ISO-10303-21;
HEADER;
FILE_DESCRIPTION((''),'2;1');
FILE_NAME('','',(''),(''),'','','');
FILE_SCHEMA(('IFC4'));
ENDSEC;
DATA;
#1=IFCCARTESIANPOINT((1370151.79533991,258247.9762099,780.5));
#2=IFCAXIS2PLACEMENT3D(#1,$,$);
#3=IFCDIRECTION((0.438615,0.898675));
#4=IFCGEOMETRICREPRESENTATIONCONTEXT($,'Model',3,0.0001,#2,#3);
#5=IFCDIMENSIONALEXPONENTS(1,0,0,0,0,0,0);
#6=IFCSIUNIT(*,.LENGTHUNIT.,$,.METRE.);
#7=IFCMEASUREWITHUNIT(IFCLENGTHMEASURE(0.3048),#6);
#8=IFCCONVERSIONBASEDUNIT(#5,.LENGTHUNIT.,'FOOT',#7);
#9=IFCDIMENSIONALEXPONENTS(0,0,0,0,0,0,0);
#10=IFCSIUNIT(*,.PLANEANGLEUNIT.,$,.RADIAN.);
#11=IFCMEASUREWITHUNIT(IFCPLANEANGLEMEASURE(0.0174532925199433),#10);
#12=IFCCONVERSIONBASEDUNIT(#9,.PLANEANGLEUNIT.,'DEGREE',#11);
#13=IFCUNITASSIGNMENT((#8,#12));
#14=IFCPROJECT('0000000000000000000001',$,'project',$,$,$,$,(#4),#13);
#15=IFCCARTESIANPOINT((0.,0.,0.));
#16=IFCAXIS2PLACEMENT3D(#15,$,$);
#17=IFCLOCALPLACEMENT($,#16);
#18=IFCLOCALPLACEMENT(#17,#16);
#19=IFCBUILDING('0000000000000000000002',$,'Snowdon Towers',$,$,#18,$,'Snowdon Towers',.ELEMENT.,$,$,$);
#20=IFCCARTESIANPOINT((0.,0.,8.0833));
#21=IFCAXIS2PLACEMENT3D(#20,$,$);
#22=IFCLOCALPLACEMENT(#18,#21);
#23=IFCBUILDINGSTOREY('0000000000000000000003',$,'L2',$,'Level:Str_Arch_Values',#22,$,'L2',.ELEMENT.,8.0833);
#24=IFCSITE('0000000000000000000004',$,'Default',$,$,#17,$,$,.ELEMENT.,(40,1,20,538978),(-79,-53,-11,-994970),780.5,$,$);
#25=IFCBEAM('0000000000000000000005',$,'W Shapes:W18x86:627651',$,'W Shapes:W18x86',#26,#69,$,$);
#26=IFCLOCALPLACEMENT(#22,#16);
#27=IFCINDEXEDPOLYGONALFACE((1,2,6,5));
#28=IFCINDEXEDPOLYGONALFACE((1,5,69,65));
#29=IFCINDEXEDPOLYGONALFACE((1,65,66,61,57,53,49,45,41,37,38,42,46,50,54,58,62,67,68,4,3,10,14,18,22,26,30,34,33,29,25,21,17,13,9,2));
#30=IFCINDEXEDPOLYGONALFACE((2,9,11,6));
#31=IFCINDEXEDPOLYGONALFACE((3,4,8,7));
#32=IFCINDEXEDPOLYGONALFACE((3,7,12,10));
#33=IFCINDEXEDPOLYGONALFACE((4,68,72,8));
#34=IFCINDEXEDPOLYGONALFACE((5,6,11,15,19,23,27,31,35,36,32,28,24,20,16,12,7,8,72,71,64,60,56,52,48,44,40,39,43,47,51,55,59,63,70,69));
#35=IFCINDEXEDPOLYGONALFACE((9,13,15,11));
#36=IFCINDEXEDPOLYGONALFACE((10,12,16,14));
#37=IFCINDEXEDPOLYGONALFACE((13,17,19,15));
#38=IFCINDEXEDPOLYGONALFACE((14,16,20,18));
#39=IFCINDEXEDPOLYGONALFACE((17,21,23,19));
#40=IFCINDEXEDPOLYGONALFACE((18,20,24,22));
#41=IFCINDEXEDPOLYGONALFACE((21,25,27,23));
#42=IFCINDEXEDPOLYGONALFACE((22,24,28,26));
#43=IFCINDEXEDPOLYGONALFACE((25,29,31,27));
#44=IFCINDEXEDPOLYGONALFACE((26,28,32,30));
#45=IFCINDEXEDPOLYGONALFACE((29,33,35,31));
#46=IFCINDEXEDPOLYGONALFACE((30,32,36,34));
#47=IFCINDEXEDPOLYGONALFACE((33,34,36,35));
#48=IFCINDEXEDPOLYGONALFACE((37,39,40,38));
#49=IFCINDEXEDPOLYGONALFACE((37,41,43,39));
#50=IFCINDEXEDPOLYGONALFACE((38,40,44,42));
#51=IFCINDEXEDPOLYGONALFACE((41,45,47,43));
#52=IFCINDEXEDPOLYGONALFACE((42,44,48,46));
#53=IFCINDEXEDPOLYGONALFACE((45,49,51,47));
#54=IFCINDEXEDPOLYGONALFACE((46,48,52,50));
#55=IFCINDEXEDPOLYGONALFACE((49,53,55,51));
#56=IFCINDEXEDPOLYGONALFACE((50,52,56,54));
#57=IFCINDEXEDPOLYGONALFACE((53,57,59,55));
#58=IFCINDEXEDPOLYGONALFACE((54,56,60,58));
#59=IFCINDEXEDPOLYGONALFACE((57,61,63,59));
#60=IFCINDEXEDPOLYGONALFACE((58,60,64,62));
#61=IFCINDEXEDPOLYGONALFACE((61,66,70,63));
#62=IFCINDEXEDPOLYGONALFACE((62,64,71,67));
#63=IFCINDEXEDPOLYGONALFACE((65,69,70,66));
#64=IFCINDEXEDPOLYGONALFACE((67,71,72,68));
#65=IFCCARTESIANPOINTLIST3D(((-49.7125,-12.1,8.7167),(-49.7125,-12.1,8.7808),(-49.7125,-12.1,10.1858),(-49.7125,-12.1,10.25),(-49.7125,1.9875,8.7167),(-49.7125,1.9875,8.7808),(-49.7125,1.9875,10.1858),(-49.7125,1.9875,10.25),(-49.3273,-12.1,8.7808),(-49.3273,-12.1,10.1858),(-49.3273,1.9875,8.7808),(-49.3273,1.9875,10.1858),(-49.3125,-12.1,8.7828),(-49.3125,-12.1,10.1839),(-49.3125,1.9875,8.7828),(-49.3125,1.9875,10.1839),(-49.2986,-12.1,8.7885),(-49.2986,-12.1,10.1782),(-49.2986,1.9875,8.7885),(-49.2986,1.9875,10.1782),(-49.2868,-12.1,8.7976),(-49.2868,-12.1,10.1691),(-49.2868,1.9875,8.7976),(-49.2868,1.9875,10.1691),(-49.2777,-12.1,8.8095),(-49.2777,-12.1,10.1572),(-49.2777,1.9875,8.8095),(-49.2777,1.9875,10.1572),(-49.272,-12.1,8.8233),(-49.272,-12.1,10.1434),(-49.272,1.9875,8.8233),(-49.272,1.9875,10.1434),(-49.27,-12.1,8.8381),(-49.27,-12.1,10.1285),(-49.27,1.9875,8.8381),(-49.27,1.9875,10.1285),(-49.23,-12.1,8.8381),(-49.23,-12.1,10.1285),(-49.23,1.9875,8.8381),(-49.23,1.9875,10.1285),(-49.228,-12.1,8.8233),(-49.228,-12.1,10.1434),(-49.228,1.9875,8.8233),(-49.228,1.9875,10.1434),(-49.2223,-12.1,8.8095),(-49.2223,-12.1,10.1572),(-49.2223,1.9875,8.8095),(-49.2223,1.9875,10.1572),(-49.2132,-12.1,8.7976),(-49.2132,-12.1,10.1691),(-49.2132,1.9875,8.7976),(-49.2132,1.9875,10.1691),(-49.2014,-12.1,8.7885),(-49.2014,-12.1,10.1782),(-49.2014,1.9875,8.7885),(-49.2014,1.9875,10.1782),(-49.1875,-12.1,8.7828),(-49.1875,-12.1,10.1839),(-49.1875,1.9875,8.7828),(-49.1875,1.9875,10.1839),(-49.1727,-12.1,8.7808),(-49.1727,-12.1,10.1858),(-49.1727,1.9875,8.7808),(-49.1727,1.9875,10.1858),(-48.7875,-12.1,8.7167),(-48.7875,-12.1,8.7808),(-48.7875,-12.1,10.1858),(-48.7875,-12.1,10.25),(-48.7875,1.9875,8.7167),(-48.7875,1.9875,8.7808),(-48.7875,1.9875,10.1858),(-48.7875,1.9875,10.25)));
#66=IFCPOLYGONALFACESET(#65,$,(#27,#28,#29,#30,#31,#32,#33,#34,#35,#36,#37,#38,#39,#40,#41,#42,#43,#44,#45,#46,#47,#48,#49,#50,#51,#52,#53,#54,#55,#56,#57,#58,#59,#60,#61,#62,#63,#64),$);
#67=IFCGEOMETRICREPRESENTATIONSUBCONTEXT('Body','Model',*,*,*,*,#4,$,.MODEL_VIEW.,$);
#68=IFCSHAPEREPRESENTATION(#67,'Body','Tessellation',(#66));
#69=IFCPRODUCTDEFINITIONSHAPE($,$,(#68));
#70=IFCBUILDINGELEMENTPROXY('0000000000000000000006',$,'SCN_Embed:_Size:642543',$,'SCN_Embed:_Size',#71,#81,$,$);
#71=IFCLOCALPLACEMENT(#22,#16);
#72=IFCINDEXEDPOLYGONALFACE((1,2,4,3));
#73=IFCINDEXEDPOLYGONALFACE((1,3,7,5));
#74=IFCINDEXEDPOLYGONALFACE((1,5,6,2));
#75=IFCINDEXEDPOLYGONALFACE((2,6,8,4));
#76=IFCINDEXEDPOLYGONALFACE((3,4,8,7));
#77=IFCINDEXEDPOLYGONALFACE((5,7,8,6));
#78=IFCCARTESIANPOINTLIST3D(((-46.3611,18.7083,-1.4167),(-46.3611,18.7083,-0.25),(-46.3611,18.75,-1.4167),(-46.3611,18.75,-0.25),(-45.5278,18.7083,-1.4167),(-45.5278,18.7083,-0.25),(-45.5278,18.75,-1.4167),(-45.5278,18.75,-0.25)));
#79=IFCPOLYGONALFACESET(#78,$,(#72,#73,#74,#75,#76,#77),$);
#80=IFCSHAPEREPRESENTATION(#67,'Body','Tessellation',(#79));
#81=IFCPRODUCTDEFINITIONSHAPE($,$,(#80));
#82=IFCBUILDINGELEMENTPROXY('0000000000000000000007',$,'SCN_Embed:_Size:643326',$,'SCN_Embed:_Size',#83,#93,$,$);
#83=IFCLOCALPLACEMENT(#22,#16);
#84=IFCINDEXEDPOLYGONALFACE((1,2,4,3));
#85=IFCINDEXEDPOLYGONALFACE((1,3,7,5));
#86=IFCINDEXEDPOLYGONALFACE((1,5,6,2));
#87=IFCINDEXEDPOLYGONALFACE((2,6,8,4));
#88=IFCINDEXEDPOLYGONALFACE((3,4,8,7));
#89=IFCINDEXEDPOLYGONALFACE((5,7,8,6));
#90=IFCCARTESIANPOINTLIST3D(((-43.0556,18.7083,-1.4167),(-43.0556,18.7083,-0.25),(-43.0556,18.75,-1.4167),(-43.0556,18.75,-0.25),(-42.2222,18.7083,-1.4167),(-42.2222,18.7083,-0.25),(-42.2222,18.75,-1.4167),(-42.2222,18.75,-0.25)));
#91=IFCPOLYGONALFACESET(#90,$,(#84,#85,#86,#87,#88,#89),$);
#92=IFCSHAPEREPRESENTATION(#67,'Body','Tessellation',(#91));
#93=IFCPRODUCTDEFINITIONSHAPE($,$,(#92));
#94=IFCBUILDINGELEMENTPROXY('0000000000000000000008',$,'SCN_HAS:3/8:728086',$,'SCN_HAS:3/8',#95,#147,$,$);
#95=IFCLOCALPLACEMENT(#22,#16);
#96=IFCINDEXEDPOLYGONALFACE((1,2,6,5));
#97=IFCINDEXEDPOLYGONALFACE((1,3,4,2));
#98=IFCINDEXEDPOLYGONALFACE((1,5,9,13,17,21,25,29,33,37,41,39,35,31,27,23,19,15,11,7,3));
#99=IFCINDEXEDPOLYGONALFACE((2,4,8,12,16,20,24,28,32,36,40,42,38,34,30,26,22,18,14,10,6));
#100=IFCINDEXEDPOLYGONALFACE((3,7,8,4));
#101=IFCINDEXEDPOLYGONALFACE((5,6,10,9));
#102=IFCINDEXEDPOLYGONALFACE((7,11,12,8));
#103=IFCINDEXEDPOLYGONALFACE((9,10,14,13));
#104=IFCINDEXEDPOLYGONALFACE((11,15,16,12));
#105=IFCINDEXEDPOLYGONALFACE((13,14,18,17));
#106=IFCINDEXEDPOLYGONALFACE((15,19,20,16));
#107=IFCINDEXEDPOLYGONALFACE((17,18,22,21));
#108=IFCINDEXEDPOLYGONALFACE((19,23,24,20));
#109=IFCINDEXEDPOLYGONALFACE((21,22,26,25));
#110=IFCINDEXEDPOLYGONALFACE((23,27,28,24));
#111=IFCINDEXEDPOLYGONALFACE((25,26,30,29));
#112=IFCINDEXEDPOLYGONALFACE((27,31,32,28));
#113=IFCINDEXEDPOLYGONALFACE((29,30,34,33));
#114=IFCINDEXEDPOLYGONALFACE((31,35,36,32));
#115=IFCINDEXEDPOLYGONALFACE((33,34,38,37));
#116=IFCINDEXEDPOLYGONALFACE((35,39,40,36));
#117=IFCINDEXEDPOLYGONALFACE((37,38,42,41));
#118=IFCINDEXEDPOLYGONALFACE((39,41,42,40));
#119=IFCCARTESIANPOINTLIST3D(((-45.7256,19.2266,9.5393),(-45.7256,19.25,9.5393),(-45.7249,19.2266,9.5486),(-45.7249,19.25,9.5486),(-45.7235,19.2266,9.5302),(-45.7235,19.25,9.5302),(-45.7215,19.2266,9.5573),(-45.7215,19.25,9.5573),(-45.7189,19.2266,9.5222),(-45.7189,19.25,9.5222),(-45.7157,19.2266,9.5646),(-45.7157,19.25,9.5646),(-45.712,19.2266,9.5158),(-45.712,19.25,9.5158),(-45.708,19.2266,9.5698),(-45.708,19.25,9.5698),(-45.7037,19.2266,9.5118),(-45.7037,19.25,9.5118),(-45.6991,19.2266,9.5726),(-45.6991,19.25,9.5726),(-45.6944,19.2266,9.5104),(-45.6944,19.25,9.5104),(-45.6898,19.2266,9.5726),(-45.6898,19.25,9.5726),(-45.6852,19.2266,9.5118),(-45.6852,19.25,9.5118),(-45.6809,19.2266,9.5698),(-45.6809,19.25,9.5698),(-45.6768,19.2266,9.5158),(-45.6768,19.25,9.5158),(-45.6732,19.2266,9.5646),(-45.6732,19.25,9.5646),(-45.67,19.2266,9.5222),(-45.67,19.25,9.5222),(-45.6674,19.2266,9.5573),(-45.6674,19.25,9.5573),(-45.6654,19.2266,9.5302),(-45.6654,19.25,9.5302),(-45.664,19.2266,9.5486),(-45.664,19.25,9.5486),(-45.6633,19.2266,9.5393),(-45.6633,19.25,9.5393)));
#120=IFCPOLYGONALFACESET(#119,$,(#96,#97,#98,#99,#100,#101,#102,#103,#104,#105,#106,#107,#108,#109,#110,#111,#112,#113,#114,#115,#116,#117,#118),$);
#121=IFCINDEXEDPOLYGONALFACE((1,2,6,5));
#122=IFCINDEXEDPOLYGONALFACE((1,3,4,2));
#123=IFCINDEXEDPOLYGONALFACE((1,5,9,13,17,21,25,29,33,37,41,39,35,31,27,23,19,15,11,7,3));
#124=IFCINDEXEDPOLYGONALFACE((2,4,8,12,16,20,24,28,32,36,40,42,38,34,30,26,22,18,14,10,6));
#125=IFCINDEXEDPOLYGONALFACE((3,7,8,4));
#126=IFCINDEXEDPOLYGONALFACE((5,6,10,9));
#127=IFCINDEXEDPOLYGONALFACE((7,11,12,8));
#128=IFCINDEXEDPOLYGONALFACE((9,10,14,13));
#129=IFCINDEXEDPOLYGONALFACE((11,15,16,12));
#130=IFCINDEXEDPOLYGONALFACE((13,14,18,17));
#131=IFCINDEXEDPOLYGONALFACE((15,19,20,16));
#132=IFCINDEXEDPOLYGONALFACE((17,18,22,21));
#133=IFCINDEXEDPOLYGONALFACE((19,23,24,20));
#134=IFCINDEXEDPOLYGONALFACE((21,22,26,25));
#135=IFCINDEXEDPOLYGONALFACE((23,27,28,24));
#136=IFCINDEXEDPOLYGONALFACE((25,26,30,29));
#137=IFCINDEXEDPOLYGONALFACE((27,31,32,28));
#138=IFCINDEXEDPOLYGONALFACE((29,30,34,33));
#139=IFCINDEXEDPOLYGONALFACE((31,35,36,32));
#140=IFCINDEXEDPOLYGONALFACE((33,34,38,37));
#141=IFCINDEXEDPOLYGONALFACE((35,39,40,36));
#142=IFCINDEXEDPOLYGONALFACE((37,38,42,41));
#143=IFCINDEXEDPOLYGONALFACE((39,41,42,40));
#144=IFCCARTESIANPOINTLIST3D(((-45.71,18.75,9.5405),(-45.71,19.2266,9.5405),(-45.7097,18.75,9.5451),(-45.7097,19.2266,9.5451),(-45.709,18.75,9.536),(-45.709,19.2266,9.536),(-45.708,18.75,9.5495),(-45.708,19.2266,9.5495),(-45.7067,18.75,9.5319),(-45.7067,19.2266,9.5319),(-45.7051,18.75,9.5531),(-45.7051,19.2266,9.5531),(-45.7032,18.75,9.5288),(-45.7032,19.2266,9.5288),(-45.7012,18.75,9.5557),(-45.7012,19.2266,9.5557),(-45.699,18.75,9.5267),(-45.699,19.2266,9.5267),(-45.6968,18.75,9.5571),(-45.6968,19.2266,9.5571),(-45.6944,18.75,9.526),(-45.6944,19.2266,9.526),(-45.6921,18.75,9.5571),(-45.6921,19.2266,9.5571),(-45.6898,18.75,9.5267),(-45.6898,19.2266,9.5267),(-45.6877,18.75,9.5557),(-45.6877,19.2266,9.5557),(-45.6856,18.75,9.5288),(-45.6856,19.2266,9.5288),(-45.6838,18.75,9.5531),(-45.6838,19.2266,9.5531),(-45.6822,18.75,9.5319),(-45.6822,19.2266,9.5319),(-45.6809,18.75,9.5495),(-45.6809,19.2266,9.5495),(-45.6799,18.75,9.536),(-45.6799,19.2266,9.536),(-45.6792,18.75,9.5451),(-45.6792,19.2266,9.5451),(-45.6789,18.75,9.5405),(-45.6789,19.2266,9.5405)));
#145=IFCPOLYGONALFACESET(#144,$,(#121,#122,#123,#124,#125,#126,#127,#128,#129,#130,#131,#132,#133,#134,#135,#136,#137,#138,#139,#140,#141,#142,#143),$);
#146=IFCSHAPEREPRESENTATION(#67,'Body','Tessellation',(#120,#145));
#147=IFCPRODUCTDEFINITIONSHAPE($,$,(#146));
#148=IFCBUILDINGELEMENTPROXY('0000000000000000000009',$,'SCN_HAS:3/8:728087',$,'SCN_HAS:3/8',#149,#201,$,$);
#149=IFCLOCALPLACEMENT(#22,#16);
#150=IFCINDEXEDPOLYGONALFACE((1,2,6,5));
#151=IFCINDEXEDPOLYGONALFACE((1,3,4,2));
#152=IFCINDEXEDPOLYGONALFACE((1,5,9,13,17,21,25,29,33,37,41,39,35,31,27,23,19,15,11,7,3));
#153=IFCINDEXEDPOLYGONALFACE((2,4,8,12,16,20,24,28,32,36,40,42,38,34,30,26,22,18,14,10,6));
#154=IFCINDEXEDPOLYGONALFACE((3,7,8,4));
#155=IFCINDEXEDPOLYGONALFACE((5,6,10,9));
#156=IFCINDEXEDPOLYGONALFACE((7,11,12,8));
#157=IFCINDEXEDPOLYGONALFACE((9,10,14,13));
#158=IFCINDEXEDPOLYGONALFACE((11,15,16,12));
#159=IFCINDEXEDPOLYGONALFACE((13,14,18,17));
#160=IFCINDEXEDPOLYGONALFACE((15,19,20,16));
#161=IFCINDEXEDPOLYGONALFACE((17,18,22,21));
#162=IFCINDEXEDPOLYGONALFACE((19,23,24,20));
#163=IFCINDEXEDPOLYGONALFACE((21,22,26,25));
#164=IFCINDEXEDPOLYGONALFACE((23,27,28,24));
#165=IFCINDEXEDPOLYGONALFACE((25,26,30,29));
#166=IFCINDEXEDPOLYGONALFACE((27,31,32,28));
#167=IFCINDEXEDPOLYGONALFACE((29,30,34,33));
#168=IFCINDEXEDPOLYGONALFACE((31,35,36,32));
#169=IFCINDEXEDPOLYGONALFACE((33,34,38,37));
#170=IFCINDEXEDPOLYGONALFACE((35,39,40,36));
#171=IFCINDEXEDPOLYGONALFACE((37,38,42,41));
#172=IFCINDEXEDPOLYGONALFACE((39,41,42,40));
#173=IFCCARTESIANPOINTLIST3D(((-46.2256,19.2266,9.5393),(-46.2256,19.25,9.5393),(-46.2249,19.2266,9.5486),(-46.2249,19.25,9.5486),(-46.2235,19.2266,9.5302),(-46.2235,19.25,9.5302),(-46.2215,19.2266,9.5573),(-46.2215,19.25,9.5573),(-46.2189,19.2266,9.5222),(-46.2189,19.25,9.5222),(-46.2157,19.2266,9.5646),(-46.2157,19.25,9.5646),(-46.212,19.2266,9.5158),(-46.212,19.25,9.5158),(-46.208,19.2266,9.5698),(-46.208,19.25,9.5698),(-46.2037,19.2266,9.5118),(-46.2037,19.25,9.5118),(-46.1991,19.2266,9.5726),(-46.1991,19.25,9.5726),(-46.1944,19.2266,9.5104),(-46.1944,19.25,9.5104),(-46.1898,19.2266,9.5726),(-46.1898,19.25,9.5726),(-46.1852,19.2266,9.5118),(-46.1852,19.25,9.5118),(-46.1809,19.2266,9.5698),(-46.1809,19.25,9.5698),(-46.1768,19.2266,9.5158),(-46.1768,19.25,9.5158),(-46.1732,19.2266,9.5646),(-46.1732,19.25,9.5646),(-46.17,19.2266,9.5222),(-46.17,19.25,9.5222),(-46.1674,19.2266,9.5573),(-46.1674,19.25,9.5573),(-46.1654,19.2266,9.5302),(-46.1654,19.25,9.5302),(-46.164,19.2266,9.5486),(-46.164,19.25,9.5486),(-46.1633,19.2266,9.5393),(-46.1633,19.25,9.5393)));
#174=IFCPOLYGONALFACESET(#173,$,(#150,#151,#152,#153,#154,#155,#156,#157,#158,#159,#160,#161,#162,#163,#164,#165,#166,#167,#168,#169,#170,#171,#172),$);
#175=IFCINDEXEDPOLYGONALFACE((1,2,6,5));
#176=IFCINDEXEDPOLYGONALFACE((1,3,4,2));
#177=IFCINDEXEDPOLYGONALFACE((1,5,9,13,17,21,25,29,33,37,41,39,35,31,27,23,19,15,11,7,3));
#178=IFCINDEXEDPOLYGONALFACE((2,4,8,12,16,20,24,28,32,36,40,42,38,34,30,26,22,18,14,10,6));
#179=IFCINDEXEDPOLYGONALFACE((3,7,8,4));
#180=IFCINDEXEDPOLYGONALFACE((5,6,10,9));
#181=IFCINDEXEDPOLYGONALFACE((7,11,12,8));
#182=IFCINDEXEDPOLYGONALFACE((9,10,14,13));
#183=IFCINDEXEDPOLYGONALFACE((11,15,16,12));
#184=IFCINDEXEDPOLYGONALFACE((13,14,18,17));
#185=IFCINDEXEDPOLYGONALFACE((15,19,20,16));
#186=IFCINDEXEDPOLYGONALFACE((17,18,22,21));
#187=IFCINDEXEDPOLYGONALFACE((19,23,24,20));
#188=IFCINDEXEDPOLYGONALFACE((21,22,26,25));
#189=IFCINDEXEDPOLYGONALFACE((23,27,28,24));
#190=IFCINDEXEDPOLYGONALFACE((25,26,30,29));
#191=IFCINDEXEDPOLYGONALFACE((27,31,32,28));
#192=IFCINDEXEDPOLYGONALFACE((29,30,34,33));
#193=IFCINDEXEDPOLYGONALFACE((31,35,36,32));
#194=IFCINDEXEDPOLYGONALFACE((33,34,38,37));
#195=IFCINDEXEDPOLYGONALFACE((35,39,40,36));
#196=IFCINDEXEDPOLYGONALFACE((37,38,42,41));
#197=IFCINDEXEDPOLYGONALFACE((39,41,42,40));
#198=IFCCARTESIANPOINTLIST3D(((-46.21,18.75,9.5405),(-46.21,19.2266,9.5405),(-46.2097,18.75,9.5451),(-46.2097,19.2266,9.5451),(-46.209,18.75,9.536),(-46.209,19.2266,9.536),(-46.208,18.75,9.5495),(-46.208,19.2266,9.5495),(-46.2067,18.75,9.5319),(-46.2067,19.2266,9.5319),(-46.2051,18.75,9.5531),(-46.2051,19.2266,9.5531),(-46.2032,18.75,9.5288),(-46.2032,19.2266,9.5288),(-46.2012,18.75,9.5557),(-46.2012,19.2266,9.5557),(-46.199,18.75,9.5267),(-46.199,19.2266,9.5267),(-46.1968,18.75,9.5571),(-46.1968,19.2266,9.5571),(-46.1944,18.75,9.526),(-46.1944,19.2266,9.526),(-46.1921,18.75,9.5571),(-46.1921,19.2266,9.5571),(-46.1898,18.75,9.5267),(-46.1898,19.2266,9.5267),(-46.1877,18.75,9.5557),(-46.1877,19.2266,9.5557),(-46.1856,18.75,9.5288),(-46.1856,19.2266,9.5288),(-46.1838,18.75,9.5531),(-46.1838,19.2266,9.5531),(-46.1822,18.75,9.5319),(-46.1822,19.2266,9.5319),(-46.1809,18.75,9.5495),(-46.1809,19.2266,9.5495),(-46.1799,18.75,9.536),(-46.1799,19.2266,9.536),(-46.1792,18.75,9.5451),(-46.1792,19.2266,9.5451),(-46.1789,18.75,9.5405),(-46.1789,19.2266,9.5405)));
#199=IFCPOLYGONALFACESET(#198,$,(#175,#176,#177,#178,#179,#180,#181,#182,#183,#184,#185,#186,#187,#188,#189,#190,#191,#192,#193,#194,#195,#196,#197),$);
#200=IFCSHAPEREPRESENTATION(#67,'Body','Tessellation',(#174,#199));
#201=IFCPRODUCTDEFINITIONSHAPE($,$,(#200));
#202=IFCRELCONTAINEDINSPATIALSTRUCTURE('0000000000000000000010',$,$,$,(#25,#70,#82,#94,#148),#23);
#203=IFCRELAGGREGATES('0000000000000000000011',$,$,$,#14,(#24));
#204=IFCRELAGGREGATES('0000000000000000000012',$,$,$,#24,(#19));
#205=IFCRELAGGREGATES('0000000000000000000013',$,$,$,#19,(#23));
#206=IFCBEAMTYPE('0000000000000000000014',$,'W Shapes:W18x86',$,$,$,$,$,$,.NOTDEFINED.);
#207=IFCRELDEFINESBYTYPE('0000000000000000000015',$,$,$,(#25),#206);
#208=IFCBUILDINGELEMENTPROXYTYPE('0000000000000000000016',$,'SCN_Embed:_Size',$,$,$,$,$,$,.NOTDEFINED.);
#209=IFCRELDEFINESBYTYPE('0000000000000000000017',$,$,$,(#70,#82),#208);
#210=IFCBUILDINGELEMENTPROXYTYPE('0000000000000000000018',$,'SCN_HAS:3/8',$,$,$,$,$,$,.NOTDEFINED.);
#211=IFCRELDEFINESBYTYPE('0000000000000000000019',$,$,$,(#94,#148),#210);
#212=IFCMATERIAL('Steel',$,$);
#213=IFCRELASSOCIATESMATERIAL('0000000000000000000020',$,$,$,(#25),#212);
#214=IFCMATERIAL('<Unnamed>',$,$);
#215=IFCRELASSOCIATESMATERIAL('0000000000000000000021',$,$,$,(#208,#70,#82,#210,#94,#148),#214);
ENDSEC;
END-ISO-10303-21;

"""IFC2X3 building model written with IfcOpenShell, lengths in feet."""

from ifc_helpers import new_model, entity, si_unit, converted_unit, direction, frame, frame_2d, origin, place, context, subcontext, project, spatial, rectangle, circle, i_section, extrude, source, transform, mapped, material, type_object, type_shapes, element, save


model = new_model("IFC2X3")

# Units and contexts
model_context = context("Model", 3, precision=0.0001, world=frame((1370151.79533991, 258247.9762099, 780.5)), true_north=direction((0.438615, 0.898675)))
body_context = subcontext(model_context, "Body", "Model", "MODEL_VIEW")
ifc_project = project(units=[converted_unit("LENGTHUNIT", "FOOT", entity("IfcLengthMeasure", 0.3048), si_unit("LENGTHUNIT", "METRE"), dimensions=[1, 0, 0, 0, 0, 0, 0]), converted_unit("PLANEANGLEUNIT", "DEGREE", entity("IfcPlaneAngleMeasure", 0.0174532925199433), si_unit("PLANEANGLEUNIT", "RADIAN"), dimensions=[0, 0, 0, 0, 0, 0, 0])], contexts=[model_context])

# Site, building, storey
site_placement = place(None, origin())
site = spatial("IfcSite", under=ifc_project, at=site_placement, Name="Default", CompositionType="ELEMENT", RefLatitude=(40, 1, 20, 538978), RefLongitude=(-79, -53, -11, -994970), RefElevation=780.5)
building_placement = place(site_placement, origin())
building = spatial("IfcBuilding", under=site, at=building_placement, Name="Snowdon Towers", LongName="Snowdon Towers", CompositionType="ELEMENT")
storey_placement = place(building_placement, frame((0.0, 0.0, 8.0833)))
storey = spatial("IfcBuildingStorey", under=building, at=storey_placement, Name="L2", ObjectType="Level:Str_Arch_Values", LongName="L2", CompositionType="ELEMENT", Elevation=8.0833)

# Shared definitions
ifc_material_1 = material(Name="Steel")

# Beam
beam_type_1 = type_object("IfcBeamType", Name="W Shapes:W18x86", PredefinedType="NOTDEFINED")
beam_1_placement = place(storey_placement, frame((-49.25, 2.5, 10.25), z_axis=(0.0, 0.0, 1.0), x_axis=(0.0, -1.0, 0.0)))
element("IfcBeam", 1, at=beam_1_placement, inside=storey, type_object=beam_type_1, material=ifc_material_1, Name="W Shapes:W18x86:627651", ObjectType="W Shapes:W18x86", context=body_context, shape_type="SweptSolid", body=[
    extrude(i_section(OverallWidth=0.925, OverallDepth=1.5333, WebThickness=0.04, FlangeThickness=0.0642, FilletRadius=0.0573, at=frame_2d((0.0, 0.0), x_axis=(0.0, 1.0))), frame((0.5125, 0.0, -0.7667), z_axis=(1.0, 0.0, 0.0), x_axis=(0.0, 0.0, -1.0)), (0.0, 0.0, 1.0), 14.0875),
])

# Building element proxies
ifc_material_2 = material(Name="<Unnamed>")
building_element_proxy_type_1 = type_object("IfcBuildingElementProxyType", Name="SCN_Embed:_Size", PredefinedType="NOTDEFINED", material=ifc_material_2)
shared_shape_1 = source(origin(), body_context, "Body", "SweptSolid", [
    extrude(rectangle(XDim=0.8333, YDim=1.1667, at=frame_2d((0.0, 0.0), x_axis=(1.0, 0.0))), frame((0.0, 0.0, -0.0417), z_axis=(0.0, 0.0, 1.0), x_axis=(-1.0, 0.0, 0.0)), (0.0, 0.0, 1.0), 0.0417),
])
type_shapes(building_element_proxy_type_1, [shared_shape_1])
for number, where, z_axis, x_axis, name in (
    (2, (-45.9444, 18.7083, -0.8333), (0.0, -1.0, 0.0), (1.0, 0.0, 0.0), "SCN_Embed:_Size:642543"),
    (3, (-42.6389, 18.7083, -0.8333), (0.0, -1.0, 0.0), (1.0, 0.0, 0.0), "SCN_Embed:_Size:643326"),
):
    element("IfcBuildingElementProxy", number, at=place(storey_placement, frame(where, z_axis=z_axis, x_axis=x_axis)), inside=storey, type_object=building_element_proxy_type_1, material=ifc_material_2, Name=name, ObjectType="SCN_Embed:_Size", context=body_context, shape_type="MappedRepresentation", body=[
        mapped(shared_shape_1, transform((0.0, 0.0, 0.0), scale=1.0)),
    ])
building_element_proxy_type_2 = type_object("IfcBuildingElementProxyType", Name="SCN_HAS:3/8", PredefinedType="NOTDEFINED", material=ifc_material_2)
shared_shape_2 = source(origin(), body_context, "Body", "SweptSolid", [
    extrude(circle(Radius=0.0312, at=frame_2d((0.0, 0.0), x_axis=(1.0, 0.0))), frame((0.0, 0.0, -0.5), z_axis=(0.0, 0.0, 1.0), x_axis=(0.0, -1.0, 0.0)), (0.0, 0.0, 1.0), 0.0234),
    extrude(circle(Radius=0.0156, at=frame_2d((0.0, 0.0), x_axis=(1.0, 0.0))), frame((0.0, 0.0, -0.4766), z_axis=(0.0, 0.0, 1.0), x_axis=(0.0, -1.0, 0.0)), (0.0, 0.0, 1.0), 0.4766),
])
type_shapes(building_element_proxy_type_2, [shared_shape_2])
for number, where, z_axis, x_axis, name in (
    (4, (-45.6944, 18.75, 9.5417), (0.0, -1.0, 0.0), (1.0, 0.0, 0.0), "SCN_HAS:3/8:728086"),
    (5, (-46.1944, 18.75, 9.5417), (0.0, -1.0, 0.0), (1.0, 0.0, 0.0), "SCN_HAS:3/8:728087"),
):
    element("IfcBuildingElementProxy", number, at=place(storey_placement, frame(where, z_axis=z_axis, x_axis=x_axis)), inside=storey, type_object=building_element_proxy_type_2, material=ifc_material_2, Name=name, ObjectType="SCN_HAS:3/8", context=body_context, shape_type="MappedRepresentation", body=[
        mapped(shared_shape_2, transform((0.0, 0.0, 0.0), scale=1.0)),
    ])

save(model, "model.ifc")
